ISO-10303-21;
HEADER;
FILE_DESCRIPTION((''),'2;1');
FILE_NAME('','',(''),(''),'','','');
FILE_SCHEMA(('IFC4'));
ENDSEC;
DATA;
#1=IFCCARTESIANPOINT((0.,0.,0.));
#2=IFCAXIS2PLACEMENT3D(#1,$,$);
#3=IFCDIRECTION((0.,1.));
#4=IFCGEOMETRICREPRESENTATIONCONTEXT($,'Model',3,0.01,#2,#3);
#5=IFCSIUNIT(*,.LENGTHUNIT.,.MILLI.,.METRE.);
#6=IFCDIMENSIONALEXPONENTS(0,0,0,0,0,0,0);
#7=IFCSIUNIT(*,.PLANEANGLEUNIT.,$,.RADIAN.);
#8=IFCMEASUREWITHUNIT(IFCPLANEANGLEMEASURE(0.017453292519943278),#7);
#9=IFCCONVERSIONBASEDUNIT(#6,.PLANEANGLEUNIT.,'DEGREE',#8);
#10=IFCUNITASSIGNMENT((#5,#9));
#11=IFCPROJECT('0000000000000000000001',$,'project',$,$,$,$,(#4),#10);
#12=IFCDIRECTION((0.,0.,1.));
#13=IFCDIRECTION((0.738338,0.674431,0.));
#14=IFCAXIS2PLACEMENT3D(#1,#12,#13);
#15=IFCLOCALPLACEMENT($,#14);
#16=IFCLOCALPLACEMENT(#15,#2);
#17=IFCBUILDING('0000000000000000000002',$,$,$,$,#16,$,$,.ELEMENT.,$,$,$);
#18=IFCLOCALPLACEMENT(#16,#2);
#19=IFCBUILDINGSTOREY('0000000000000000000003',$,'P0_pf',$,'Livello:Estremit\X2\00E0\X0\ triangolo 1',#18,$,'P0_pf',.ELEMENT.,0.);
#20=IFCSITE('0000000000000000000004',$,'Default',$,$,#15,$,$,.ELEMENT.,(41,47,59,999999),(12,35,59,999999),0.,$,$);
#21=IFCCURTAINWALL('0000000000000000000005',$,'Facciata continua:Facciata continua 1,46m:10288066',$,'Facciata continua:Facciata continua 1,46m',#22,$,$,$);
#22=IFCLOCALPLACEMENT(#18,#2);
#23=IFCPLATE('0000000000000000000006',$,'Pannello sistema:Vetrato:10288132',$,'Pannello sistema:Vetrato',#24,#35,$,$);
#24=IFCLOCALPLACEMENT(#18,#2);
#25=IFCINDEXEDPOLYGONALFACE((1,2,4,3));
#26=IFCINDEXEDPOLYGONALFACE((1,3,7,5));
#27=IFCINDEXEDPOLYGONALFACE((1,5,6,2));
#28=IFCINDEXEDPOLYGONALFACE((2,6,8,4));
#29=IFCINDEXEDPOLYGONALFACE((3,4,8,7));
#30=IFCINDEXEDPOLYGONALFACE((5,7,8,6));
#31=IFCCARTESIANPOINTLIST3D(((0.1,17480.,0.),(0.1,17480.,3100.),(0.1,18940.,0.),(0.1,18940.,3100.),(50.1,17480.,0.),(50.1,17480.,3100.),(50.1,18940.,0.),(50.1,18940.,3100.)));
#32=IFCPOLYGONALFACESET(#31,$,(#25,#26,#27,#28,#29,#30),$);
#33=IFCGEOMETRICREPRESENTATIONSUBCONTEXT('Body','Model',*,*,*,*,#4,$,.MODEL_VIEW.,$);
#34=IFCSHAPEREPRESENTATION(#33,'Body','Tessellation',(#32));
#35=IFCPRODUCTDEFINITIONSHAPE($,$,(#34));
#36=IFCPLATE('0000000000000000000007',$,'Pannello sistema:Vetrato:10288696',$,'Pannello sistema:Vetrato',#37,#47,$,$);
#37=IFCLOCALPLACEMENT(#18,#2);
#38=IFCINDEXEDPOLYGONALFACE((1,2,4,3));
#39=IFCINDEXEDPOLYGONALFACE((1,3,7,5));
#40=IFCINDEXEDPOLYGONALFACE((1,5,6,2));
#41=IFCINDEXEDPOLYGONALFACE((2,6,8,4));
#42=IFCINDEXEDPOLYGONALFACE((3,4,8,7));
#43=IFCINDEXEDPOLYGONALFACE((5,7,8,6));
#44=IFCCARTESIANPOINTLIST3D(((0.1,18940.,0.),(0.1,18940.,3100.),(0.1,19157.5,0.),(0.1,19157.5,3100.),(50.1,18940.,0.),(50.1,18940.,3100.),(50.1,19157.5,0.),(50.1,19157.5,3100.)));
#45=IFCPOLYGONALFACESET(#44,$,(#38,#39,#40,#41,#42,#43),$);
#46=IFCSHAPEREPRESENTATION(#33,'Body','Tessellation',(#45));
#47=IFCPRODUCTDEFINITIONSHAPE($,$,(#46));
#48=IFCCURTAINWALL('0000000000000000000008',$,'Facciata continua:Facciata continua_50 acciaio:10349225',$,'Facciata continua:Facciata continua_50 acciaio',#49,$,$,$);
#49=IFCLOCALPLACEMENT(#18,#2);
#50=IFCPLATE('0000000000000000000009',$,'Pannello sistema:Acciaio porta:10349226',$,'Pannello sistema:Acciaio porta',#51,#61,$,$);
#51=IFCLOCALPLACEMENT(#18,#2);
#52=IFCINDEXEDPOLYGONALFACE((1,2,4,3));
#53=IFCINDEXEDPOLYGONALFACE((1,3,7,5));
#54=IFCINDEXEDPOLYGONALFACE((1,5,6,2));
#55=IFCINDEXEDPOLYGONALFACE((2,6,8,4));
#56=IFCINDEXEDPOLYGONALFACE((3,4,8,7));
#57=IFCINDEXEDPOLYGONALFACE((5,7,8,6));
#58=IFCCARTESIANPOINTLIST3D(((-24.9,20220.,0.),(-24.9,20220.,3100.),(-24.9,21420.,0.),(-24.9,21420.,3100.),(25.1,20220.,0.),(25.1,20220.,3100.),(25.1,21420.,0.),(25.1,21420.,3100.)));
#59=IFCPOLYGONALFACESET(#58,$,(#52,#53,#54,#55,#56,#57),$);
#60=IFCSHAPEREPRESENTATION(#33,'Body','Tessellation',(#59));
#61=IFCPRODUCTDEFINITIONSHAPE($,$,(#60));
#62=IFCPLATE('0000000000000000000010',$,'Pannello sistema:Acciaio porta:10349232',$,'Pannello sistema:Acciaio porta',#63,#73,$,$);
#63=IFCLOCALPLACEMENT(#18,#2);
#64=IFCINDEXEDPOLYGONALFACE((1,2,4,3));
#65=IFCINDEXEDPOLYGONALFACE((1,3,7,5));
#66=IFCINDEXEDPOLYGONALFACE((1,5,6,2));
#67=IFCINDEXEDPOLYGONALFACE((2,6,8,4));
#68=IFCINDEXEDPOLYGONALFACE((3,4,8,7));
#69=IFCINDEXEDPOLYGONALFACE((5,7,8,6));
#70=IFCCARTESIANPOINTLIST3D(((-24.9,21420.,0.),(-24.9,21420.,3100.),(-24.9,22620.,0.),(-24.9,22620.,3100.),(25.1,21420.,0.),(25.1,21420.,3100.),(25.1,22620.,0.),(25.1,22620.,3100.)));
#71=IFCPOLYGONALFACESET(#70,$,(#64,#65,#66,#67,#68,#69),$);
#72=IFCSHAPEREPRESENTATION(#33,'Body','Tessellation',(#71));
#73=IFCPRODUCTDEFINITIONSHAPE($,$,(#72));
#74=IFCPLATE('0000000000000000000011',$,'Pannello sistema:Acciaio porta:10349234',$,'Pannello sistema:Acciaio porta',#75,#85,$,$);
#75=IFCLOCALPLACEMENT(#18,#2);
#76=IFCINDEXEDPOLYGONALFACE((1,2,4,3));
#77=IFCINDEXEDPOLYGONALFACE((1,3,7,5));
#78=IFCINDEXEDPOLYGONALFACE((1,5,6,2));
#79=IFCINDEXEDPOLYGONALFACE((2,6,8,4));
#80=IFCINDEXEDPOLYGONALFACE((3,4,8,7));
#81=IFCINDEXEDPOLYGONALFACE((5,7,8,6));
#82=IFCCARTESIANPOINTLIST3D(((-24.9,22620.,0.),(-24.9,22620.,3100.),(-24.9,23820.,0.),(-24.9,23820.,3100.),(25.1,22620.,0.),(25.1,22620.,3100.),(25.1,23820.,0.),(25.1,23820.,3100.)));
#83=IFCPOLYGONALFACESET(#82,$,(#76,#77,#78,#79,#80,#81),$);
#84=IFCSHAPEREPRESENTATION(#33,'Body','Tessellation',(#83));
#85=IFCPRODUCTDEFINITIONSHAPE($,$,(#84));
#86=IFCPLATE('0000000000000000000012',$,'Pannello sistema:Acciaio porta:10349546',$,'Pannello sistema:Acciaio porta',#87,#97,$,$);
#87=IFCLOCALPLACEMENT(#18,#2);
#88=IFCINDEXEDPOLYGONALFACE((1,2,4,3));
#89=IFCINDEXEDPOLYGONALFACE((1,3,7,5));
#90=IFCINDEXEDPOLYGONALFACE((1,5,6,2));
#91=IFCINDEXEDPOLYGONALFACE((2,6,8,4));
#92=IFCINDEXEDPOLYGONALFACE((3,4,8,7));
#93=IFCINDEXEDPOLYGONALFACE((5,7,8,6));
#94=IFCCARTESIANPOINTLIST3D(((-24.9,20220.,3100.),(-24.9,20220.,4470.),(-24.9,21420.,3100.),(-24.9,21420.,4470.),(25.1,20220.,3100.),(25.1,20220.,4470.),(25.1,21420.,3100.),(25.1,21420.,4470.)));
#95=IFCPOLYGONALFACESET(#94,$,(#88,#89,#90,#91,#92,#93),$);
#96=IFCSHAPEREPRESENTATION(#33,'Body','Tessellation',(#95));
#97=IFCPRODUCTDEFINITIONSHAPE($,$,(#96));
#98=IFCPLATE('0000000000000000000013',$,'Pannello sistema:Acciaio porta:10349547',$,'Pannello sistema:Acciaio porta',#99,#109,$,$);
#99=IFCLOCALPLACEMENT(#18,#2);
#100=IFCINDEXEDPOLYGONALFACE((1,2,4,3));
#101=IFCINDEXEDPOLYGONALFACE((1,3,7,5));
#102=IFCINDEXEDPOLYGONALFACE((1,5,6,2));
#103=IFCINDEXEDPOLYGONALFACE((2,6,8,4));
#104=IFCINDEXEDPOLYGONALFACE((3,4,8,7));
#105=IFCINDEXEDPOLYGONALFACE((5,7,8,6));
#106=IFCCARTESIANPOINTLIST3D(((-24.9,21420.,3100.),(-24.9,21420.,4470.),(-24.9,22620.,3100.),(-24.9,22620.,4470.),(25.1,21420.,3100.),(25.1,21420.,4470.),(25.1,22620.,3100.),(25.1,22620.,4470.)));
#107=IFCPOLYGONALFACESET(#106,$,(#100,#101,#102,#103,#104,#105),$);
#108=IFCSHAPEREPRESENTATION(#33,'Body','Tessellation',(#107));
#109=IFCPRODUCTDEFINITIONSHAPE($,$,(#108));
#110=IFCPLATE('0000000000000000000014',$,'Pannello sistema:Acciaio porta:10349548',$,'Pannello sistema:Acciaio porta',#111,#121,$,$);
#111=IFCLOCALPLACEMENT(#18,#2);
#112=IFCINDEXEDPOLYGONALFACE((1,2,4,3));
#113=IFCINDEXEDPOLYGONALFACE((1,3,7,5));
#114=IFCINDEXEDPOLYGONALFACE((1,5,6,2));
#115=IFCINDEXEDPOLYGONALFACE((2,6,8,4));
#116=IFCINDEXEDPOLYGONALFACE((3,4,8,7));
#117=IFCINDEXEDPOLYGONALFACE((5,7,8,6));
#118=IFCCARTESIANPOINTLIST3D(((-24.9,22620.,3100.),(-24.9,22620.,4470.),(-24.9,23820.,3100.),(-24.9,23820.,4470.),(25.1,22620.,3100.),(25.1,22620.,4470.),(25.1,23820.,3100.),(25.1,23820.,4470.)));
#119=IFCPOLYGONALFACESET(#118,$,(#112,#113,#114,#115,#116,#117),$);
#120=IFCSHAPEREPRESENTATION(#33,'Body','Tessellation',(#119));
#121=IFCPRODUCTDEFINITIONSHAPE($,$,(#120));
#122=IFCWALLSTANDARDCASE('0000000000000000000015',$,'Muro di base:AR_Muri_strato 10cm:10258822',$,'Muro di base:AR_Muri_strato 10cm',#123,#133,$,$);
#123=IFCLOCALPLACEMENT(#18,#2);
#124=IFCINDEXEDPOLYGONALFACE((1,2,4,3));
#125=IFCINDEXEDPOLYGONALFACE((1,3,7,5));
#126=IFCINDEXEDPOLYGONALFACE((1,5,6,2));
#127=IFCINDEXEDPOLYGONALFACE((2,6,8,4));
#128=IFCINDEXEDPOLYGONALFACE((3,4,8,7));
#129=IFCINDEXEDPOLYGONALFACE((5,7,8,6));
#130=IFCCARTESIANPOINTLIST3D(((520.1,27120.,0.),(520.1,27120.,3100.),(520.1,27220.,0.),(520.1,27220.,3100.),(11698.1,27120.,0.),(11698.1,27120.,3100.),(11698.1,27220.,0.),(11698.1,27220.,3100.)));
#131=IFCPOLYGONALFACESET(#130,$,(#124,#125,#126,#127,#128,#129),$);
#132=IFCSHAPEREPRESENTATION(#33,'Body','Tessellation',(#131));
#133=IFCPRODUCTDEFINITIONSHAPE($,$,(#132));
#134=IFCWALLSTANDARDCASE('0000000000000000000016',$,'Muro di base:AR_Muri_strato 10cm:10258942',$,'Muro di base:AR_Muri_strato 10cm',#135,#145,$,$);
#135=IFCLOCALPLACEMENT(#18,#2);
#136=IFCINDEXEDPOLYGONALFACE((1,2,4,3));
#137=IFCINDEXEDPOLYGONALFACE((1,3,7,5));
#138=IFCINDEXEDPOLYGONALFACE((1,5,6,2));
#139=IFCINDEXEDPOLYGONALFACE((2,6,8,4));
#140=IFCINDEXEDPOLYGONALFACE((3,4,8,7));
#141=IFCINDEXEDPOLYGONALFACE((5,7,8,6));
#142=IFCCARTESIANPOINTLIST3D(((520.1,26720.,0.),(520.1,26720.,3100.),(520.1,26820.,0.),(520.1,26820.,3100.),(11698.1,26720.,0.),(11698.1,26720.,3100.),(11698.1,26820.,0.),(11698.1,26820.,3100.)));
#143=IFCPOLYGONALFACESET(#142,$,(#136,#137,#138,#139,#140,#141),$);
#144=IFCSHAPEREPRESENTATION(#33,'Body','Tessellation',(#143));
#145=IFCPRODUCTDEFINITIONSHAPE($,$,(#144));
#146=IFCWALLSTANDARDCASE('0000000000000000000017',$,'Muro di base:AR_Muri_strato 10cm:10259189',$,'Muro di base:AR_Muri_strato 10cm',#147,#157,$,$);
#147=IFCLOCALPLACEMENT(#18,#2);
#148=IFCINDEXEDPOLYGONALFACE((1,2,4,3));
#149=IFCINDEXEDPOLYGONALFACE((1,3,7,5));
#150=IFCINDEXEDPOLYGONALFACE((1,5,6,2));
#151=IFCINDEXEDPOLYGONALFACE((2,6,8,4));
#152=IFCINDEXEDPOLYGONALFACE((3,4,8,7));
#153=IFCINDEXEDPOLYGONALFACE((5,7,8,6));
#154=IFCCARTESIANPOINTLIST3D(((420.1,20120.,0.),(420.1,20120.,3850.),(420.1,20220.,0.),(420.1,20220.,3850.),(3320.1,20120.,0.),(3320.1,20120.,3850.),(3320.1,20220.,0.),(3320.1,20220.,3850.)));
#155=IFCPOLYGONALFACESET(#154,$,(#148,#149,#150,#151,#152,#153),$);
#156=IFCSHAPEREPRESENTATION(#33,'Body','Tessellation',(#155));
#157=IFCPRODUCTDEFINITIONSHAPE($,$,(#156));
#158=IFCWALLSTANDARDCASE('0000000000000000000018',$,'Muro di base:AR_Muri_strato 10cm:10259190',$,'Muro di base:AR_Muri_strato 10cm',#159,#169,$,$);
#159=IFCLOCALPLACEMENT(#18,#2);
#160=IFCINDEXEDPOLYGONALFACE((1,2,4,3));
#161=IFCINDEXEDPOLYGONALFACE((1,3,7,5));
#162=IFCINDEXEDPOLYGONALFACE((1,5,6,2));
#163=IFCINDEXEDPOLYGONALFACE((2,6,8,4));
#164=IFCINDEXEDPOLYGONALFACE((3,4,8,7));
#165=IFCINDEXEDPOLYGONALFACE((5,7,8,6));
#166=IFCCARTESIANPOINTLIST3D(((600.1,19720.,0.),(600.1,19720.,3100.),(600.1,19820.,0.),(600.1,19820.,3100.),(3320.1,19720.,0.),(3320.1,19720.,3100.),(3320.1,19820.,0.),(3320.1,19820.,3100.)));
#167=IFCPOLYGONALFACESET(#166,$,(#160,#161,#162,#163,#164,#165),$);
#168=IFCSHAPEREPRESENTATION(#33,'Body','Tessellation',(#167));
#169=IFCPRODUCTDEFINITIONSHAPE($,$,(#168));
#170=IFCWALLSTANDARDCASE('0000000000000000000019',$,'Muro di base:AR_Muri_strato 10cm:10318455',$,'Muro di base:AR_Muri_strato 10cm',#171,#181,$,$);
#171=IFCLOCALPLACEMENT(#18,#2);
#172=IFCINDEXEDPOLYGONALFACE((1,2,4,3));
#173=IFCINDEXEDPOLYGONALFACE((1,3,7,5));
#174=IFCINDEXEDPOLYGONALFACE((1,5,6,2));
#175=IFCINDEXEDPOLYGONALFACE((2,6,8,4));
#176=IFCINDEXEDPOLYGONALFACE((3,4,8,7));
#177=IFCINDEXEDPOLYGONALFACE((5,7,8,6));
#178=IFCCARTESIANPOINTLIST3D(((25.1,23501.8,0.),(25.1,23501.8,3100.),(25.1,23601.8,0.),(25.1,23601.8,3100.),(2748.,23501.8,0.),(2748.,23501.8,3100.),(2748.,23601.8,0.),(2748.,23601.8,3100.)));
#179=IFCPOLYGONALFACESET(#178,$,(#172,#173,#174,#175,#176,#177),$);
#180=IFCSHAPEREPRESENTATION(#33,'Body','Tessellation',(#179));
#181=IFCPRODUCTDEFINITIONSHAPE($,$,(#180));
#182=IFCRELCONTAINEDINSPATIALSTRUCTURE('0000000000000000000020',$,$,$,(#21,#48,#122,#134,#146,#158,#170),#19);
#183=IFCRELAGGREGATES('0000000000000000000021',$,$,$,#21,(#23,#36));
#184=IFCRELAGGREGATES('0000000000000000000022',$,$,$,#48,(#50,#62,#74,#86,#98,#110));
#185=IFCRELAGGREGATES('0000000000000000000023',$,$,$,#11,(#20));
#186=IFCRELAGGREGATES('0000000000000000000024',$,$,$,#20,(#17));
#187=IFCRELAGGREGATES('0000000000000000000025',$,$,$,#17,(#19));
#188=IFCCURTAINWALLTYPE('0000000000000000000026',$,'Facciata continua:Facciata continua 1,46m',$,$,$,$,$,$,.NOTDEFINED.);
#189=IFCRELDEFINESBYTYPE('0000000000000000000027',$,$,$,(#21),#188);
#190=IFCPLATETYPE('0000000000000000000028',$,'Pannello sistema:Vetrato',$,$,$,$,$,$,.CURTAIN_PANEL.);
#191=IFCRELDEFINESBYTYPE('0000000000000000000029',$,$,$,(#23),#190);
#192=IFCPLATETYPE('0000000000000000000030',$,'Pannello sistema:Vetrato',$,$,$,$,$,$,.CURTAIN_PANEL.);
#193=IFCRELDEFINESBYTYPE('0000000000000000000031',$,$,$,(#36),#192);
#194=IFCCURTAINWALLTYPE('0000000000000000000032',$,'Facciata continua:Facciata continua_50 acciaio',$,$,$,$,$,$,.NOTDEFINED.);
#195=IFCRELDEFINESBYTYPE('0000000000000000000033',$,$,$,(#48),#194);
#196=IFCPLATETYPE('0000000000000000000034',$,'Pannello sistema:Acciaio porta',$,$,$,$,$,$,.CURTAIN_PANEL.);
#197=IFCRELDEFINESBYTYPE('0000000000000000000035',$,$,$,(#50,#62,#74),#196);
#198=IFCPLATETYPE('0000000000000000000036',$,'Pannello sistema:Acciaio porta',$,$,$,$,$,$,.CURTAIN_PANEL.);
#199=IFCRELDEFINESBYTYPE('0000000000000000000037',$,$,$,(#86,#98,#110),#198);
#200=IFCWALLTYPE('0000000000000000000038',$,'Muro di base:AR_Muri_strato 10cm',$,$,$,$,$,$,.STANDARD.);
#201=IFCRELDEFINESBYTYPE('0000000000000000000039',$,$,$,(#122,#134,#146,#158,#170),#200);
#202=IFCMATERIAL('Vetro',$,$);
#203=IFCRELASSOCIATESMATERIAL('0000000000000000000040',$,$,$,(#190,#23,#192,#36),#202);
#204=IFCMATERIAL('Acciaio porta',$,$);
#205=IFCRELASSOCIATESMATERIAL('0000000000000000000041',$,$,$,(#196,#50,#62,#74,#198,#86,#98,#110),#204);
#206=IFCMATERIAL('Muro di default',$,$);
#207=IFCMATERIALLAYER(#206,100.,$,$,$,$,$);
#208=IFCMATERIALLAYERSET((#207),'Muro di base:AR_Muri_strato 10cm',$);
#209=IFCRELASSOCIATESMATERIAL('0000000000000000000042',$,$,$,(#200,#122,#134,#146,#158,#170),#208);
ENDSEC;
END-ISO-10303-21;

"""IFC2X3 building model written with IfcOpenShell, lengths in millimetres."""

from ifc_helpers import new_model, entity, si_unit, converted_unit, direction, frame, frame_2d, origin, origin_2d_with_axis, place, context, subcontext, project, spatial, rectangle, extrude, source, transform, mapped, material, layer, layer_set, layer_usage, type_object, type_shapes, element, aggregate, save


model = new_model("IFC2X3")

# Units and contexts
model_context = context("Model", 3, precision=0.01, world=origin(), true_north=direction((0.0, 1.0)))
body_context = subcontext(model_context, "Body", "Model", "MODEL_VIEW")
ifc_project = project(units=[si_unit("LENGTHUNIT", "METRE", prefix="MILLI"), converted_unit("PLANEANGLEUNIT", "DEGREE", entity("IfcPlaneAngleMeasure", 0.017453292519943278), si_unit("PLANEANGLEUNIT", "RADIAN"), dimensions=[0, 0, 0, 0, 0, 0, 0])], contexts=[model_context])

# Site, building, storey
site_placement = place(None, frame((0.0, 0.0, 0.0), z_axis=(0.0, 0.0, 1.0), x_axis=(0.738338, 0.674431, 0.0)))
site = spatial("IfcSite", under=ifc_project, at=site_placement, Name="Default", CompositionType="ELEMENT", RefLatitude=(41, 47, 59, 999999), RefLongitude=(12, 35, 59, 999999), RefElevation=0.0)
building_placement = place(site_placement, origin())
building = spatial("IfcBuilding", under=site, at=building_placement, CompositionType="ELEMENT")
storey_placement = place(building_placement, origin())
storey = spatial("IfcBuildingStorey", under=building, at=storey_placement, Name="P0_pf", ObjectType="Livello:Estremità triangolo 1", LongName="P0_pf", CompositionType="ELEMENT", Elevation=0.0)

# Curtain walls, plates
curtain_wall_type_1 = type_object("IfcCurtainWallType", Name="Facciata continua:Facciata continua 1,46m", PredefinedType="NOTDEFINED")
curtain_wall_1_placement = place(storey_placement, origin())
curtain_wall_1 = element("IfcCurtainWall", 1, at=curtain_wall_1_placement, inside=storey, type_object=curtain_wall_type_1, Name="Facciata continua:Facciata continua 1,46m:10288066", ObjectType="Facciata continua:Facciata continua 1,46m")
ifc_material_1 = material(Name="Vetro")
plate_type_1 = type_object("IfcPlateType", Name="Pannello sistema:Vetrato", PredefinedType="CURTAIN_PANEL", material=ifc_material_1)
shared_shape_1 = source(origin(), body_context, "Body", "SweptSolid", [
    extrude(rectangle(XDim=50.0, YDim=1460.0, at=origin_2d_with_axis()), frame((0.0, -25.0, 0.0), z_axis=(0.0, 0.0, 1.0), x_axis=(0.0, 1.0, 0.0)), (0.0, 0.0, 1.0), 3100.0),
])
type_shapes(plate_type_1, [shared_shape_1])
plate_1_placement = place(curtain_wall_1_placement, frame((0.1, 18210.0, 0.0), z_axis=(0.0, 0.0, 1.0), x_axis=(0.0, 1.0, 0.0)))
plate_1 = element("IfcPlate", 2, at=plate_1_placement, type_object=plate_type_1, material=ifc_material_1, Name="Pannello sistema:Vetrato:10288132", ObjectType="Pannello sistema:Vetrato", context=body_context, shape_type="MappedRepresentation", body=[
    mapped(shared_shape_1, transform((0.0, 0.0, 0.0), scale=1.0)),
])
plate_type_2 = type_object("IfcPlateType", Name="Pannello sistema:Vetrato", PredefinedType="CURTAIN_PANEL", material=ifc_material_1)
shared_shape_2 = source(origin(), body_context, "Body", "SweptSolid", [
    extrude(rectangle(XDim=50.0, YDim=217.5, at=origin_2d_with_axis()), frame((0.0, -25.0, 0.0), z_axis=(0.0, 0.0, 1.0), x_axis=(0.0, 1.0, 0.0)), (0.0, 0.0, 1.0), 3100.0),
])
type_shapes(plate_type_2, [shared_shape_2])
plate_2_placement = place(curtain_wall_1_placement, frame((0.1, 19048.7, 0.0), z_axis=(0.0, 0.0, 1.0), x_axis=(0.0, 1.0, 0.0)))
plate_2 = element("IfcPlate", 3, at=plate_2_placement, type_object=plate_type_2, material=ifc_material_1, Name="Pannello sistema:Vetrato:10288696", ObjectType="Pannello sistema:Vetrato", context=body_context, shape_type="MappedRepresentation", body=[
    mapped(shared_shape_2, transform((0.0, 0.0, 0.0), scale=1.0)),
])
aggregate(curtain_wall_1, [plate_1, plate_2])
curtain_wall_type_2 = type_object("IfcCurtainWallType", Name="Facciata continua:Facciata continua_50 acciaio", PredefinedType="NOTDEFINED")
curtain_wall_2_placement = place(storey_placement, origin())
curtain_wall_2 = element("IfcCurtainWall", 4, at=curtain_wall_2_placement, inside=storey, type_object=curtain_wall_type_2, Name="Facciata continua:Facciata continua_50 acciaio:10349225", ObjectType="Facciata continua:Facciata continua_50 acciaio")
ifc_material_2 = material(Name="Acciaio porta")
plate_type_3 = type_object("IfcPlateType", Name="Pannello sistema:Acciaio porta", PredefinedType="CURTAIN_PANEL", material=ifc_material_2)
shared_shape_3 = source(origin(), body_context, "Body", "SweptSolid", [
    extrude(rectangle(XDim=50.0, YDim=1200.0, at=origin_2d_with_axis()), frame((0.0, 0.0, 0.0), z_axis=(0.0, 0.0, 1.0), x_axis=(0.0, 1.0, 0.0)), (0.0, 0.0, 1.0), 3100.0),
])
type_shapes(plate_type_3, [shared_shape_3])
plate_3_placement = place(curtain_wall_2_placement, frame((0.1, 20820.0, 0.0), z_axis=(0.0, 0.0, 1.0), x_axis=(0.0, 1.0, 0.0)))
plate_3 = element("IfcPlate", 5, at=plate_3_placement, type_object=plate_type_3, material=ifc_material_2, Name="Pannello sistema:Acciaio porta:10349226", ObjectType="Pannello sistema:Acciaio porta", context=body_context, shape_type="MappedRepresentation", body=[
    mapped(shared_shape_3, transform((0.0, 0.0, 0.0), scale=1.0)),
])
plate_4_placement = place(curtain_wall_2_placement, frame((0.1, 22020.0, 0.0), z_axis=(0.0, 0.0, 1.0), x_axis=(0.0, 1.0, 0.0)))
plate_4 = element("IfcPlate", 6, at=plate_4_placement, type_object=plate_type_3, material=ifc_material_2, Name="Pannello sistema:Acciaio porta:10349232", ObjectType="Pannello sistema:Acciaio porta", context=body_context, shape_type="MappedRepresentation", body=[
    mapped(shared_shape_3, transform((0.0, 0.0, 0.0), scale=1.0)),
])
plate_5_placement = place(curtain_wall_2_placement, frame((0.1, 23220.0, 0.0), z_axis=(0.0, 0.0, 1.0), x_axis=(0.0, 1.0, 0.0)))
plate_5 = element("IfcPlate", 7, at=plate_5_placement, type_object=plate_type_3, material=ifc_material_2, Name="Pannello sistema:Acciaio porta:10349234", ObjectType="Pannello sistema:Acciaio porta", context=body_context, shape_type="MappedRepresentation", body=[
    mapped(shared_shape_3, transform((0.0, 0.0, 0.0), scale=1.0)),
])
plate_type_4 = type_object("IfcPlateType", Name="Pannello sistema:Acciaio porta", PredefinedType="CURTAIN_PANEL", material=ifc_material_2)
shared_shape_4 = source(origin(), body_context, "Body", "SweptSolid", [
    extrude(rectangle(XDim=50.0, YDim=1200.0, at=origin_2d_with_axis()), frame((0.0, 0.0, 0.0), z_axis=(0.0, 0.0, 1.0), x_axis=(0.0, 1.0, 0.0)), (0.0, 0.0, 1.0), 1370.0),
])
type_shapes(plate_type_4, [shared_shape_4])
plate_6_placement = place(curtain_wall_2_placement, frame((0.1, 20820.0, 3100.0), z_axis=(0.0, 0.0, 1.0), x_axis=(0.0, 1.0, 0.0)))
plate_6 = element("IfcPlate", 8, at=plate_6_placement, type_object=plate_type_4, material=ifc_material_2, Name="Pannello sistema:Acciaio porta:10349546", ObjectType="Pannello sistema:Acciaio porta", context=body_context, shape_type="MappedRepresentation", body=[
    mapped(shared_shape_4, transform((0.0, 0.0, 0.0), scale=1.0)),
])
plate_7_placement = place(curtain_wall_2_placement, frame((0.1, 22020.0, 3100.0), z_axis=(0.0, 0.0, 1.0), x_axis=(0.0, 1.0, 0.0)))
plate_7 = element("IfcPlate", 9, at=plate_7_placement, type_object=plate_type_4, material=ifc_material_2, Name="Pannello sistema:Acciaio porta:10349547", ObjectType="Pannello sistema:Acciaio porta", context=body_context, shape_type="MappedRepresentation", body=[
    mapped(shared_shape_4, transform((0.0, 0.0, 0.0), scale=1.0)),
])
plate_8_placement = place(curtain_wall_2_placement, frame((0.1, 23220.0, 3100.0), z_axis=(0.0, 0.0, 1.0), x_axis=(0.0, 1.0, 0.0)))
plate_8 = element("IfcPlate", 10, at=plate_8_placement, type_object=plate_type_4, material=ifc_material_2, Name="Pannello sistema:Acciaio porta:10349548", ObjectType="Pannello sistema:Acciaio porta", context=body_context, shape_type="MappedRepresentation", body=[
    mapped(shared_shape_4, transform((0.0, 0.0, 0.0), scale=1.0)),
])
aggregate(curtain_wall_2, [plate_3, plate_4, plate_5, plate_6, plate_7, plate_8])

# Walls
ifc_material_3 = material(Name="Muro di default")
ifc_layer_1 = layer(ifc_material_3, 100.0)
ifc_layer_set_1 = layer_set([ifc_layer_1], Name="Muro di base:AR_Muri_strato 10cm")
ifc_layer_usage_1 = layer_usage(ifc_layer_set_1, "AXIS2", "NEGATIVE", 50.0)
wall_type_1 = type_object("IfcWallType", Name="Muro di base:AR_Muri_strato 10cm", PredefinedType="STANDARD", material=ifc_layer_set_1)
wall_1_placement = place(storey_placement, frame((520.1, 27170.0, 0.0)))
element("IfcWallStandardCase", 11, at=wall_1_placement, inside=storey, type_object=wall_type_1, material=ifc_layer_usage_1, Name="Muro di base:AR_Muri_strato 10cm:10258822", ObjectType="Muro di base:AR_Muri_strato 10cm", context=body_context, shape_type="SweptSolid", body=[
    extrude(rectangle(XDim=11178.0, YDim=100.0, at=frame_2d((5589.0, 0.0), x_axis=(-1.0, 0.0))), origin(), (0.0, 0.0, 1.0), 3100.0),
])
ifc_layer_usage_2 = layer_usage(ifc_layer_set_1, "AXIS2", "POSITIVE", -50.0)
wall_2_placement = place(storey_placement, frame((520.1, 26770.0, 0.0)))
element("IfcWallStandardCase", 12, at=wall_2_placement, inside=storey, type_object=wall_type_1, material=ifc_layer_usage_2, Name="Muro di base:AR_Muri_strato 10cm:10258942", ObjectType="Muro di base:AR_Muri_strato 10cm", context=body_context, shape_type="SweptSolid", body=[
    extrude(rectangle(XDim=11178.0, YDim=100.0, at=frame_2d((5589.0, 0.0), x_axis=(-1.0, 0.0))), origin(), (0.0, 0.0, 1.0), 3100.0),
])
ifc_layer_usage_3 = layer_usage(ifc_layer_set_1, "AXIS2", "NEGATIVE", 50.0)
wall_3_placement = place(storey_placement, frame((420.1, 20170.0, 0.0)))
element("IfcWallStandardCase", 13, at=wall_3_placement, inside=storey, type_object=wall_type_1, material=ifc_layer_usage_3, Name="Muro di base:AR_Muri_strato 10cm:10259189", ObjectType="Muro di base:AR_Muri_strato 10cm", context=body_context, shape_type="SweptSolid", body=[
    extrude(rectangle(XDim=2900.0, YDim=100.0, at=frame_2d((1450.0, 0.0), x_axis=(-1.0, 0.0))), origin(), (0.0, 0.0, 1.0), 3850.0),
])
ifc_layer_usage_4 = layer_usage(ifc_layer_set_1, "AXIS2", "POSITIVE", -50.0)
wall_4_placement = place(storey_placement, frame((600.1, 19770.0, 0.0)))
element("IfcWallStandardCase", 14, at=wall_4_placement, inside=storey, type_object=wall_type_1, material=ifc_layer_usage_4, Name="Muro di base:AR_Muri_strato 10cm:10259190", ObjectType="Muro di base:AR_Muri_strato 10cm", context=body_context, shape_type="SweptSolid", body=[
    extrude(rectangle(XDim=2720.0, YDim=100.0, at=frame_2d((1360.0, 0.0), x_axis=(-1.0, 0.0))), origin(), (0.0, 0.0, 1.0), 3100.0),
])

# Wall
ifc_layer_usage_5 = layer_usage(ifc_layer_set_1, "AXIS2", "NEGATIVE", 50.0)
wall_5_placement = place(storey_placement, frame((25.1, 23551.8, 0.0)))
element("IfcWallStandardCase", 15, at=wall_5_placement, inside=storey, type_object=wall_type_1, material=ifc_layer_usage_5, Name="Muro di base:AR_Muri_strato 10cm:10318455", ObjectType="Muro di base:AR_Muri_strato 10cm", context=body_context, shape_type="SweptSolid", body=[
    extrude(rectangle(XDim=2722.9, YDim=100.0, at=frame_2d((1361.5, 0.0), x_axis=(-1.0, 0.0))), origin(), (0.0, 0.0, 1.0), 3100.0),
])

save(model, "model.ifc")
